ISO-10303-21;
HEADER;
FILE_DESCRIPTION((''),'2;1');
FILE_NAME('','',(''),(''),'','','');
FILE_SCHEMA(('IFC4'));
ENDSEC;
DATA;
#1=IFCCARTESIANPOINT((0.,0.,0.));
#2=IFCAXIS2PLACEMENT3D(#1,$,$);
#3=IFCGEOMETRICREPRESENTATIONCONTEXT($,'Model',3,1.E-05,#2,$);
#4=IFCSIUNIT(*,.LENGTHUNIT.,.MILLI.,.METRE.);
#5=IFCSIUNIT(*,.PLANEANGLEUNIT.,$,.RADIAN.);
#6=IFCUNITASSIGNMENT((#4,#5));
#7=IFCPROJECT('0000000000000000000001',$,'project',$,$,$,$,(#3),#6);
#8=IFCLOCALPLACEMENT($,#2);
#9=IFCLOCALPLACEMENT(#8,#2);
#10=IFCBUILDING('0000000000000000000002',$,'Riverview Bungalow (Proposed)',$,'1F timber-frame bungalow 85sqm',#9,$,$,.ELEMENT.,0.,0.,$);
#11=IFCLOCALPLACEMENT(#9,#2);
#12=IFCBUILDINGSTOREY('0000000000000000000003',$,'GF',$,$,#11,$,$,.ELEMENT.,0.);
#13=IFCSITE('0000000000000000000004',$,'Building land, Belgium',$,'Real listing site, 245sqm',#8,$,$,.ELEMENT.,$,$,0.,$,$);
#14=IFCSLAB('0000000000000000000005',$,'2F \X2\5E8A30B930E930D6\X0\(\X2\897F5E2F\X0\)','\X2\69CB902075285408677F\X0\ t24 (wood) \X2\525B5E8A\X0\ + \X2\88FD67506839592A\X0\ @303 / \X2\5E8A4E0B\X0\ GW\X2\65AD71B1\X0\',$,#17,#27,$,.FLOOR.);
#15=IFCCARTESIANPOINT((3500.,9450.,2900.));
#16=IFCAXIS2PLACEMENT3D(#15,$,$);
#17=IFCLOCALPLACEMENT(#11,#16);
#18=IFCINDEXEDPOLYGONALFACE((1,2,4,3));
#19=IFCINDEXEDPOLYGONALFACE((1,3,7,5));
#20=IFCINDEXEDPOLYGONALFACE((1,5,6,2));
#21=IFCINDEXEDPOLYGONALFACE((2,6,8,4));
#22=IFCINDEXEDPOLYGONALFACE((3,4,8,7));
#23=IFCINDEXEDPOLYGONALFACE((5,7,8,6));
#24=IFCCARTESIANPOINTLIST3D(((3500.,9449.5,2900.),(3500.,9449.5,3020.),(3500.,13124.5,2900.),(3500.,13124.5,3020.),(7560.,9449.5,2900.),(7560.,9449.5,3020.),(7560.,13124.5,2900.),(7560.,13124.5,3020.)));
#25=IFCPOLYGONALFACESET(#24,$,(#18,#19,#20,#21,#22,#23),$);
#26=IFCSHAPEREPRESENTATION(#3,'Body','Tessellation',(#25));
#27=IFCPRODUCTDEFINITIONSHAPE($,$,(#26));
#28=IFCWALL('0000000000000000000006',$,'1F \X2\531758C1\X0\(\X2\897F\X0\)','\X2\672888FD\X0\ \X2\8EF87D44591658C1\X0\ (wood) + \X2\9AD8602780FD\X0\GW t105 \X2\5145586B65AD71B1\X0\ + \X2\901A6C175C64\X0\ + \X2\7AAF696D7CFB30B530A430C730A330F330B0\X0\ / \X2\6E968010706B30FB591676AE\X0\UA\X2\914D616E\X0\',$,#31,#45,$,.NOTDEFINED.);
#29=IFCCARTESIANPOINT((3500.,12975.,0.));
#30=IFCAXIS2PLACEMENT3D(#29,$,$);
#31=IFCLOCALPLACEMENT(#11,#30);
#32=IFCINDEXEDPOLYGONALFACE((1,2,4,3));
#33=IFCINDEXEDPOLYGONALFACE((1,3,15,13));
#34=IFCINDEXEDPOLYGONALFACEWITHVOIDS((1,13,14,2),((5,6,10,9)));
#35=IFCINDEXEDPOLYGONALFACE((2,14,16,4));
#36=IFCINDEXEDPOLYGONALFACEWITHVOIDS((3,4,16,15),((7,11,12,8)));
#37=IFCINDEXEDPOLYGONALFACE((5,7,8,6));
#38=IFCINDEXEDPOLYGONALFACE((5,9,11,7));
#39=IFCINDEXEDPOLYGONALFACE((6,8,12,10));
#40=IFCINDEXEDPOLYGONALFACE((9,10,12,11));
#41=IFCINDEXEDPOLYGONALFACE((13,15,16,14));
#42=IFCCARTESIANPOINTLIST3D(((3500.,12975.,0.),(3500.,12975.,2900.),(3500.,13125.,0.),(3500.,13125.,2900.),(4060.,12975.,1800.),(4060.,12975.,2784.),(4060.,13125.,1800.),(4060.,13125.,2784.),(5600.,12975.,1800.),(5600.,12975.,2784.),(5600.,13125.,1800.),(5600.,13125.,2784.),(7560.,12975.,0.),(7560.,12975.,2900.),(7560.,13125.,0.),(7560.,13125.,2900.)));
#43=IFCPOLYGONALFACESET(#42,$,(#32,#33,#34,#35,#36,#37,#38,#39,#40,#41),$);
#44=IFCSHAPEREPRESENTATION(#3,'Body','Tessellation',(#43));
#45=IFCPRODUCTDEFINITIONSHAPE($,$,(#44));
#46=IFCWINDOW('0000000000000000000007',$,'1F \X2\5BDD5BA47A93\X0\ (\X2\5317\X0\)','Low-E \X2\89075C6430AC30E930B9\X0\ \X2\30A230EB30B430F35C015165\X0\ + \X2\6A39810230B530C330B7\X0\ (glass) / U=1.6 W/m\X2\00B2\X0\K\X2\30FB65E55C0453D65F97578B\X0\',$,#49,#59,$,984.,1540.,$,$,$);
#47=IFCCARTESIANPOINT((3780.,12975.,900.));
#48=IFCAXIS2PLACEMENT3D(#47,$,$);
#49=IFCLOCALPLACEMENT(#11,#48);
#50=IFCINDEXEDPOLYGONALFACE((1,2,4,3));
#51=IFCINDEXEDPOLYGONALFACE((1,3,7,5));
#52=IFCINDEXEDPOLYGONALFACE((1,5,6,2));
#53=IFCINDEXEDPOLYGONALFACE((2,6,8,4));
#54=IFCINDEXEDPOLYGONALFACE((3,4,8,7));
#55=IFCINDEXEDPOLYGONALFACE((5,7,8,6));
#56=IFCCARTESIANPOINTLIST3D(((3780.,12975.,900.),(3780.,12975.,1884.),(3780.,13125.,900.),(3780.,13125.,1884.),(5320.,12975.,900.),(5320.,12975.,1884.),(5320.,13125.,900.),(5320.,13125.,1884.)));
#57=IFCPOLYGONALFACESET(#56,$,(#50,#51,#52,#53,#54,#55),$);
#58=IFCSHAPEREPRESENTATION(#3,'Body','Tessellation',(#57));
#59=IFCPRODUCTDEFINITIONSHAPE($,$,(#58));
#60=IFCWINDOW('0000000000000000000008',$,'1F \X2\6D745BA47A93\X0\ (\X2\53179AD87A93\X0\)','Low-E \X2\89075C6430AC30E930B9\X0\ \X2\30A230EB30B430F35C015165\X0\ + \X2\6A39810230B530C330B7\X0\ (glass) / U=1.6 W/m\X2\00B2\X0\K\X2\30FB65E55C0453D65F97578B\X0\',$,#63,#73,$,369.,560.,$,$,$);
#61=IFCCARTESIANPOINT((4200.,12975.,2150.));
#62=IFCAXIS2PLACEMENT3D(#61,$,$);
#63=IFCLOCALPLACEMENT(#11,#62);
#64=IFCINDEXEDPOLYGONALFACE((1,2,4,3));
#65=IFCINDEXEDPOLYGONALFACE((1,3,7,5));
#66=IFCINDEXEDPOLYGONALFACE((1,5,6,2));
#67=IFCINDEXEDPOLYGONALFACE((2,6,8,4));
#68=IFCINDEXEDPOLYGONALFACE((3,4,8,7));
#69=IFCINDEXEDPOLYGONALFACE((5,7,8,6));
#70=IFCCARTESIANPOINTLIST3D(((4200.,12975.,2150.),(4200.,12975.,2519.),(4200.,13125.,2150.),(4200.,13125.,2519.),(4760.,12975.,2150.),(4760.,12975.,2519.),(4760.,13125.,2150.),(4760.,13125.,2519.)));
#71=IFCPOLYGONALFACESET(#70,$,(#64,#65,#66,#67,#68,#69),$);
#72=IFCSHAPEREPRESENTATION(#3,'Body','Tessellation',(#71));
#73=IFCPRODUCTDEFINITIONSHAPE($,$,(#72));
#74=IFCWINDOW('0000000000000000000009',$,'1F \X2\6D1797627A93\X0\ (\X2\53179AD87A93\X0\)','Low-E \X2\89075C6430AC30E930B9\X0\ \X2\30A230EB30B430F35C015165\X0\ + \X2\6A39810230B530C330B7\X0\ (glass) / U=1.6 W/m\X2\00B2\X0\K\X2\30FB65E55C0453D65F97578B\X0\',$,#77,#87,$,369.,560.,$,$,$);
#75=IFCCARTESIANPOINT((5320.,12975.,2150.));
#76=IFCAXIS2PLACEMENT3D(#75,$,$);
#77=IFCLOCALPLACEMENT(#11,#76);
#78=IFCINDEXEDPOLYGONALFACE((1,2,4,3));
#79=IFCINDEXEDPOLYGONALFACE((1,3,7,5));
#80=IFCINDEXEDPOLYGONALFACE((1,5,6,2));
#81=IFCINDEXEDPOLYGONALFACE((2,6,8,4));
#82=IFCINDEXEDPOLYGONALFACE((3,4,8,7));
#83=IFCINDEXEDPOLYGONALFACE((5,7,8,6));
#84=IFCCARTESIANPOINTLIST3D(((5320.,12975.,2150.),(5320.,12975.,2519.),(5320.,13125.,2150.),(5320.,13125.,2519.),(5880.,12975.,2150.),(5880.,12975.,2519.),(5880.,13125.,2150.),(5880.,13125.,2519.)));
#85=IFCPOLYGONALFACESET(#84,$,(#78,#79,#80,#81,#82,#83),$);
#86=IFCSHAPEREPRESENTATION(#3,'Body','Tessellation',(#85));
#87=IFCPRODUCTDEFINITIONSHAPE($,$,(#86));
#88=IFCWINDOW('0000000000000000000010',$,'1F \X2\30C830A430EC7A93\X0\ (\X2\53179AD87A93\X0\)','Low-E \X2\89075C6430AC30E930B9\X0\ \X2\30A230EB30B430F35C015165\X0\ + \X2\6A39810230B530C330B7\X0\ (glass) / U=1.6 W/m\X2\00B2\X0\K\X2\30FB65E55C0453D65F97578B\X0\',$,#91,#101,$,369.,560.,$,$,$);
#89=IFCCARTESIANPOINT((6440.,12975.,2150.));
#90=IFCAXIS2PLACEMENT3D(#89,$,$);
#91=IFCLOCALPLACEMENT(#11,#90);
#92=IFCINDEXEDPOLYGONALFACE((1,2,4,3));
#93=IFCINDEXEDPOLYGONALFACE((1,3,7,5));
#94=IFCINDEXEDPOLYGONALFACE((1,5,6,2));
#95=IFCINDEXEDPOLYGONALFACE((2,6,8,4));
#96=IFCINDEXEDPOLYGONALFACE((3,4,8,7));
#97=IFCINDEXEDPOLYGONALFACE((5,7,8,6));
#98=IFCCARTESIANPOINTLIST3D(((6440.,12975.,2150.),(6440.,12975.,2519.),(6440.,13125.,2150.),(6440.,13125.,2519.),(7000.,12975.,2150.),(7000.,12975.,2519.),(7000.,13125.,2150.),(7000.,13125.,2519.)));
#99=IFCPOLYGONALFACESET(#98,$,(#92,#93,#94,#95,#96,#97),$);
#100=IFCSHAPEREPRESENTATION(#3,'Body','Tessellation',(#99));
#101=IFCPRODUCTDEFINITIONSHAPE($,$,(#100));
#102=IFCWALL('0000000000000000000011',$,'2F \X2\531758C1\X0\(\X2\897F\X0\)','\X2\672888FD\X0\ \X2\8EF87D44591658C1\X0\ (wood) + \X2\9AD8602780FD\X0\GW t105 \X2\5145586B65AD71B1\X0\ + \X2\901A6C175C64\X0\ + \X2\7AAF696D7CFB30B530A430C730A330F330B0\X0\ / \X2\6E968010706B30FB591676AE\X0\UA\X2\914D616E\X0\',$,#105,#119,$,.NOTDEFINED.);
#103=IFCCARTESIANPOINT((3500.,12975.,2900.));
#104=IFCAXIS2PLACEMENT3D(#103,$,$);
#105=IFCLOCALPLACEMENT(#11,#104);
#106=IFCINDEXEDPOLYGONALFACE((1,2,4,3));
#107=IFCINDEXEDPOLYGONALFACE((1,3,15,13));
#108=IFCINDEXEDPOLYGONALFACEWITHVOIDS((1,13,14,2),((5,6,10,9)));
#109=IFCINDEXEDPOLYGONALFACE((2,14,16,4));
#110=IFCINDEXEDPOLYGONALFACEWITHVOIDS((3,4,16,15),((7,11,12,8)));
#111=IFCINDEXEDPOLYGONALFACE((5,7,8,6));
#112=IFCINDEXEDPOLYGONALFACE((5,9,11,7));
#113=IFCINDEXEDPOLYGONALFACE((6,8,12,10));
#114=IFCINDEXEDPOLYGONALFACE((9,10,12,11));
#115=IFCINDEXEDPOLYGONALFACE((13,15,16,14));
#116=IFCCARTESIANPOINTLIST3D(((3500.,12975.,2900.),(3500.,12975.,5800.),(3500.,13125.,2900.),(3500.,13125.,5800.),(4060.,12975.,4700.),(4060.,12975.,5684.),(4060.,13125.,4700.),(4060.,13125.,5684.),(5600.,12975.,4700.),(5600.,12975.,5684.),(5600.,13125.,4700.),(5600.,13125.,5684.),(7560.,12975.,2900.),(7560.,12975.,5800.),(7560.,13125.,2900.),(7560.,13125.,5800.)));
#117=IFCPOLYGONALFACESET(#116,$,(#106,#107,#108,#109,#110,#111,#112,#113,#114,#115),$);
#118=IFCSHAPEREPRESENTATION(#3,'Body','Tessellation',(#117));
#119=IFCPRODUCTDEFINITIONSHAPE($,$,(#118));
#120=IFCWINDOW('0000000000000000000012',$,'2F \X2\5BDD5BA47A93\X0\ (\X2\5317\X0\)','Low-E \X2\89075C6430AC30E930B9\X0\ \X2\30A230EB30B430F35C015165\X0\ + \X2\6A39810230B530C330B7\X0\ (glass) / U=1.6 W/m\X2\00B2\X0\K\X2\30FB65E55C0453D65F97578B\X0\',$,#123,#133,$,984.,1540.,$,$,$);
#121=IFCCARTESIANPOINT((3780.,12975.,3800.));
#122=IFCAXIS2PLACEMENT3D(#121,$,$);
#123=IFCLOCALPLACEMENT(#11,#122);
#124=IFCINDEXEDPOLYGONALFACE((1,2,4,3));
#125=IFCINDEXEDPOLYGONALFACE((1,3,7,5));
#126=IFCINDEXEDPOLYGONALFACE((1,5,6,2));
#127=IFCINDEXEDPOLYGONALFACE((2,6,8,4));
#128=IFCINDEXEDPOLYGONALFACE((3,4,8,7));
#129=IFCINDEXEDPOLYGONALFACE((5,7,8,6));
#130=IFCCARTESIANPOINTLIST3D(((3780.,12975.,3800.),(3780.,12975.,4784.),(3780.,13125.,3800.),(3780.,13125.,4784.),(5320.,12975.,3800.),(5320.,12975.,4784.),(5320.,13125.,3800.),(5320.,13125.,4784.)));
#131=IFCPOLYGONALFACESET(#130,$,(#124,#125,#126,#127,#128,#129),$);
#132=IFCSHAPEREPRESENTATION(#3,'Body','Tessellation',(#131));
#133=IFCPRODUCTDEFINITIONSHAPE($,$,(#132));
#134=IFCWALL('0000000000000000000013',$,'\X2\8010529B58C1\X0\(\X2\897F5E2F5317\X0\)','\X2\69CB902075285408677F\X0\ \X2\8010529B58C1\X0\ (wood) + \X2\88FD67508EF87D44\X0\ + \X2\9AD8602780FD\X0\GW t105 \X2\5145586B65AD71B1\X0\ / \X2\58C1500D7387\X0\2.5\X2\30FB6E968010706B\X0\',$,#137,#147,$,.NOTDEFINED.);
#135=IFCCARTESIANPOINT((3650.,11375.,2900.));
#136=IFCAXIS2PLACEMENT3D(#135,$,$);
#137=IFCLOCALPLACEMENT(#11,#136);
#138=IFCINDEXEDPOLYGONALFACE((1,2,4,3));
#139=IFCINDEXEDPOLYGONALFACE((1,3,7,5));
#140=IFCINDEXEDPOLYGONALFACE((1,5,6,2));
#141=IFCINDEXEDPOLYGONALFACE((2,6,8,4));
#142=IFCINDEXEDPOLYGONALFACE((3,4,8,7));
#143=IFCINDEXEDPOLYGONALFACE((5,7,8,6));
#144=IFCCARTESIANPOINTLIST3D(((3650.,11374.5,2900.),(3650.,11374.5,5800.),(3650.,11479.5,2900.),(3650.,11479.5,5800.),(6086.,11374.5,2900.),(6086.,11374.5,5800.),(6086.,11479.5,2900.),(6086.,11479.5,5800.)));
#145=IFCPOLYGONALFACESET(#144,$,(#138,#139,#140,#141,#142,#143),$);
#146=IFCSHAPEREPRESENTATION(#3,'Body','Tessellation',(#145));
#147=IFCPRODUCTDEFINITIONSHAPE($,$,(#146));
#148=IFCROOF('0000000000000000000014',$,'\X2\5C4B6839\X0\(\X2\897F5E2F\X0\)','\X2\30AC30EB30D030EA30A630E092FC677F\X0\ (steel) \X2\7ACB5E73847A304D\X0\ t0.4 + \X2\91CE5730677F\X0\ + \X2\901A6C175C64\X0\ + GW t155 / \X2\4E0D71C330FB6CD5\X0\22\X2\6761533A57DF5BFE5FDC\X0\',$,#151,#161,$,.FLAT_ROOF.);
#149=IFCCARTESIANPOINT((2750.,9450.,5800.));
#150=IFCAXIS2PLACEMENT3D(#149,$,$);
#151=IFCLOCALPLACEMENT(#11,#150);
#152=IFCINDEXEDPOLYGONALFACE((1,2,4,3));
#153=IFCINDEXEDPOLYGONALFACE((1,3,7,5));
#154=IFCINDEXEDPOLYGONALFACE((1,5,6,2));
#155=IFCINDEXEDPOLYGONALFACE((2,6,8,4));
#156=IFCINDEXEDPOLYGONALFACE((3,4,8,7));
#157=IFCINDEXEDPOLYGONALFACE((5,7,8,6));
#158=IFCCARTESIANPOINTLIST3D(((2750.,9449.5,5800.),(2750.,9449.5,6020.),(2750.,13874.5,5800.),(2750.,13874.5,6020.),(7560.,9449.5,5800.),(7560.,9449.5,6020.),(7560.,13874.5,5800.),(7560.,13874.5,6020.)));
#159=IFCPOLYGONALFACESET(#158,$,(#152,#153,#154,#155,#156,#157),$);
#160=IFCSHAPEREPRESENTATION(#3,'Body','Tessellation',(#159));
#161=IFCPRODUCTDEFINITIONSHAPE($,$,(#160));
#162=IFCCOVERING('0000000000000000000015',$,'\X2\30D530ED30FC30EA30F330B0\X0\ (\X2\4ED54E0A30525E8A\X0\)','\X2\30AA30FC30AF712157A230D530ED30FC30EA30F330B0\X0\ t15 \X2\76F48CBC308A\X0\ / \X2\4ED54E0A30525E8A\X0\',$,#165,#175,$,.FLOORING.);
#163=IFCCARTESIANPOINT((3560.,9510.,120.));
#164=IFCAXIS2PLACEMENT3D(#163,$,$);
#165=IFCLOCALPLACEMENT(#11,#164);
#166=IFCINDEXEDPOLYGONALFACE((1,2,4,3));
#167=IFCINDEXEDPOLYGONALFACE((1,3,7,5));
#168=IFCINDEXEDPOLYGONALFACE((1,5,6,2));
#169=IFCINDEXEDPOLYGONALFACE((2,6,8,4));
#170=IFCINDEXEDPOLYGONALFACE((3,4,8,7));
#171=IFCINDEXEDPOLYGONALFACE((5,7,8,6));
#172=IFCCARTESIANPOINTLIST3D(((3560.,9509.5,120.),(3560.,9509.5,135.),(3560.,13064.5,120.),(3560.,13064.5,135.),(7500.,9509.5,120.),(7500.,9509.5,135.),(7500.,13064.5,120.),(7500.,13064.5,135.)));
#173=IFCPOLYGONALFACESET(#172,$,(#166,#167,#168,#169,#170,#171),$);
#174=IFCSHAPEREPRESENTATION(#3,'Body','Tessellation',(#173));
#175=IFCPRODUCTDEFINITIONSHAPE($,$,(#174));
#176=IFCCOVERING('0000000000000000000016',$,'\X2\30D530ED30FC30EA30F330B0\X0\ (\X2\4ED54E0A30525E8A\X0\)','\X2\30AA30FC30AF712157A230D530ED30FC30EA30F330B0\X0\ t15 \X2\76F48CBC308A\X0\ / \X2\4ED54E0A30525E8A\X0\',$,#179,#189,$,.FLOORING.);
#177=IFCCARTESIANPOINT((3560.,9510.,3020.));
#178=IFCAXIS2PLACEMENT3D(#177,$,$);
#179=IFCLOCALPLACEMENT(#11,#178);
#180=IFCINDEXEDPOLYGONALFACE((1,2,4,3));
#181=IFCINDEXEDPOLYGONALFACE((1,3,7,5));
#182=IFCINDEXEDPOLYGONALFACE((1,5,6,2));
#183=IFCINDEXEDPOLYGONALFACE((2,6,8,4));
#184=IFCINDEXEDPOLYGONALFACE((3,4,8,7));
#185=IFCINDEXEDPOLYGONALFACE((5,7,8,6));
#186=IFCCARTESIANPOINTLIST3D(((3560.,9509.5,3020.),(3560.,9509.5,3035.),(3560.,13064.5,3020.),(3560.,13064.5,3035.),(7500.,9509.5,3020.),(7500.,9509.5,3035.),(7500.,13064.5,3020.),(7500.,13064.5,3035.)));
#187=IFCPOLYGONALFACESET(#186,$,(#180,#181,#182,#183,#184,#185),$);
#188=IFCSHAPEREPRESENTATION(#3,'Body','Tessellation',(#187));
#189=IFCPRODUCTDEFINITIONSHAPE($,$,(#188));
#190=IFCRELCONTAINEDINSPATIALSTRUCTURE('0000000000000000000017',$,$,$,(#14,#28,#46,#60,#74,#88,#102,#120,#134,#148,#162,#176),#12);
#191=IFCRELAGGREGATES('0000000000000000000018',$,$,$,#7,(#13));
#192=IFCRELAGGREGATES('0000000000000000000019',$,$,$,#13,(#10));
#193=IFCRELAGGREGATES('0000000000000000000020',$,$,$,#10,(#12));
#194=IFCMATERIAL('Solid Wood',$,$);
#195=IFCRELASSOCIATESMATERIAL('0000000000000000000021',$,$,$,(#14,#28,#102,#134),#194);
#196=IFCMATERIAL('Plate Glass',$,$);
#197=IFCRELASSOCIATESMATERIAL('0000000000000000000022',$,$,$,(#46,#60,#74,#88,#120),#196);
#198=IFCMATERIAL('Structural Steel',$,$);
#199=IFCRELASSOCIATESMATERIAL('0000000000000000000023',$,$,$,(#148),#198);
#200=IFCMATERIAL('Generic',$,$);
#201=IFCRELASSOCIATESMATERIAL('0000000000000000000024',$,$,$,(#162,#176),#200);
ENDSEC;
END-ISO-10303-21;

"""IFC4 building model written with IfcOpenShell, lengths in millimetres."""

from ifc_helpers import new_model, si_unit, frame, frame_2d, origin, place, context, project, spatial, rectangle, extrude, material, element, fill, save


model = new_model("IFC4")

# Units and contexts
model_context = context("Model", 3, precision=1e-05, world=origin())
ifc_project = project(units=[si_unit("LENGTHUNIT", "METRE", prefix="MILLI"), si_unit("PLANEANGLEUNIT", "RADIAN")], contexts=[model_context])

# Site, building, storey
site_placement = place(None, origin())
site = spatial("IfcSite", under=ifc_project, at=site_placement, Name="Building land, Belgium", ObjectType="Real listing site, 245sqm", CompositionType="ELEMENT", RefElevation=0.0)
building_placement = place(site_placement, origin())
building = spatial("IfcBuilding", under=site, at=building_placement, Name="Riverview Bungalow (Proposed)", ObjectType="1F timber-frame bungalow 85sqm", CompositionType="ELEMENT", ElevationOfRefHeight=0.0, ElevationOfTerrain=0.0)
storey_placement = place(building_placement, origin())
storey = spatial("IfcBuildingStorey", under=building, at=storey_placement, Name="GF", CompositionType="ELEMENT", Elevation=0.0)

# Slab
ifc_material_1 = material(Name="Solid Wood")
slab_1_placement = place(storey_placement, frame((3500.0, 9450.0, 2900.0)))
element("IfcSlab", 1, at=slab_1_placement, inside=storey, material=ifc_material_1, Name="2F 床スラブ(西帯)", Description="構造用合板 t24 (wood) 剛床 + 製材根太 @303 / 床下 GW断熱", PredefinedType="FLOOR", context=model_context, shape_type="SweptSolid", body=[
    extrude(rectangle(XDim=4060.0, YDim=3675.0, at=frame_2d((2030.0, 1837.0))), frame((3500.0, 9450.0, 2900.0)), (0.0, 0.0, 1.0), 120.0),
])

# Wall, openings, windows
wall_1_placement = place(storey_placement, frame((3500.0, 12975.0, 0.0)))
wall_1 = element("IfcWall", 2, at=wall_1_placement, inside=storey, material=ifc_material_1, Name="1F 北壁(西)", Description="木製 軸組外壁 (wood) + 高性能GW t105 充填断熱 + 通気層 + 窯業系サイディング / 準耐火・外皮UA配慮", PredefinedType="NOTDEFINED", context=model_context, shape_type="SweptSolid", body=[
    extrude(rectangle(XDim=4060.0, YDim=150.0, at=frame_2d((2030.0, 75.0))), frame((3500.0, 12975.0, 0.0)), (0.0, 0.0, 1.0), 2900.0),
])
opening_1_placement = place(storey_placement, frame((3780.0, 12975.0, 900.0)))
opening_1 = element("IfcOpeningElement", 3, at=opening_1_placement, cuts=wall_1, PredefinedType="NOTDEFINED", context=model_context, shape_type="SweptSolid", body=[
    extrude(rectangle(XDim=1540.0, YDim=150.0, at=frame_2d((770.0, 75.0))), frame((3780.0, 12975.0, 900.0)), (0.0, 0.0, 1.0), 984.0),
])
opening_2_placement = place(storey_placement, frame((4200.0, 12975.0, 2150.0)))
opening_2 = element("IfcOpeningElement", 4, at=opening_2_placement, cuts=wall_1, PredefinedType="NOTDEFINED", context=model_context, shape_type="SweptSolid", body=[
    extrude(rectangle(XDim=560.0, YDim=150.0, at=frame_2d((280.0, 75.0))), frame((4200.0, 12975.0, 2150.0)), (0.0, 0.0, 1.0), 369.0),
])
opening_3_placement = place(storey_placement, frame((5320.0, 12975.0, 2150.0)))
opening_3 = element("IfcOpeningElement", 5, at=opening_3_placement, cuts=wall_1, PredefinedType="NOTDEFINED", context=model_context, shape_type="SweptSolid", body=[
    extrude(rectangle(XDim=560.0, YDim=150.0, at=frame_2d((280.0, 75.0))), frame((5320.0, 12975.0, 2150.0)), (0.0, 0.0, 1.0), 369.0),
])
opening_4_placement = place(storey_placement, frame((6440.0, 12975.0, 2150.0)))
opening_4 = element("IfcOpeningElement", 6, at=opening_4_placement, cuts=wall_1, PredefinedType="NOTDEFINED", context=model_context, shape_type="SweptSolid", body=[
    extrude(rectangle(XDim=560.0, YDim=150.0, at=frame_2d((280.0, 75.0))), frame((6440.0, 12975.0, 2150.0)), (0.0, 0.0, 1.0), 369.0),
])
ifc_material_2 = material(Name="Plate Glass")
window_1_placement = place(storey_placement, frame((3780.0, 12975.0, 900.0)))
window_1 = element("IfcWindow", 7, at=window_1_placement, inside=storey, material=ifc_material_2, Name="1F 寝室窓 (北)", Description="Low-E 複層ガラス アルゴン封入 + 樹脂サッシ (glass) / U=1.6 W/m²K・日射取得型", OverallHeight=984.0, OverallWidth=1540.0, context=model_context, shape_type="SweptSolid", body=[
    extrude(rectangle(XDim=1540.0, YDim=150.0, at=frame_2d((770.0, 75.0))), frame((3780.0, 12975.0, 900.0)), (0.0, 0.0, 1.0), 984.0),
])
fill(opening_1, window_1)
window_2_placement = place(storey_placement, frame((4200.0, 12975.0, 2150.0)))
window_2 = element("IfcWindow", 8, at=window_2_placement, inside=storey, material=ifc_material_2, Name="1F 浴室窓 (北高窓)", Description="Low-E 複層ガラス アルゴン封入 + 樹脂サッシ (glass) / U=1.6 W/m²K・日射取得型", OverallHeight=369.0, OverallWidth=560.0, context=model_context, shape_type="SweptSolid", body=[
    extrude(rectangle(XDim=560.0, YDim=150.0, at=frame_2d((280.0, 75.0))), frame((4200.0, 12975.0, 2150.0)), (0.0, 0.0, 1.0), 369.0),
])
fill(opening_2, window_2)
window_3_placement = place(storey_placement, frame((5320.0, 12975.0, 2150.0)))
window_3 = element("IfcWindow", 9, at=window_3_placement, inside=storey, material=ifc_material_2, Name="1F 洗面窓 (北高窓)", Description="Low-E 複層ガラス アルゴン封入 + 樹脂サッシ (glass) / U=1.6 W/m²K・日射取得型", OverallHeight=369.0, OverallWidth=560.0, context=model_context, shape_type="SweptSolid", body=[
    extrude(rectangle(XDim=560.0, YDim=150.0, at=frame_2d((280.0, 75.0))), frame((5320.0, 12975.0, 2150.0)), (0.0, 0.0, 1.0), 369.0),
])
fill(opening_3, window_3)
window_4_placement = place(storey_placement, frame((6440.0, 12975.0, 2150.0)))
window_4 = element("IfcWindow", 10, at=window_4_placement, inside=storey, material=ifc_material_2, Name="1F トイレ窓 (北高窓)", Description="Low-E 複層ガラス アルゴン封入 + 樹脂サッシ (glass) / U=1.6 W/m²K・日射取得型", OverallHeight=369.0, OverallWidth=560.0, context=model_context, shape_type="SweptSolid", body=[
    extrude(rectangle(XDim=560.0, YDim=150.0, at=frame_2d((280.0, 75.0))), frame((6440.0, 12975.0, 2150.0)), (0.0, 0.0, 1.0), 369.0),
])
fill(opening_4, window_4)

# Wall, opening, window
wall_2_placement = place(storey_placement, frame((3500.0, 12975.0, 2900.0)))
wall_2 = element("IfcWall", 11, at=wall_2_placement, inside=storey, material=ifc_material_1, Name="2F 北壁(西)", Description="木製 軸組外壁 (wood) + 高性能GW t105 充填断熱 + 通気層 + 窯業系サイディング / 準耐火・外皮UA配慮", PredefinedType="NOTDEFINED", context=model_context, shape_type="SweptSolid", body=[
    extrude(rectangle(XDim=4060.0, YDim=150.0, at=frame_2d((2030.0, 75.0))), frame((3500.0, 12975.0, 2900.0)), (0.0, 0.0, 1.0), 2900.0),
])
opening_5_placement = place(storey_placement, frame((3780.0, 12975.0, 3800.0)))
opening_5 = element("IfcOpeningElement", 12, at=opening_5_placement, cuts=wall_2, PredefinedType="NOTDEFINED", context=model_context, shape_type="SweptSolid", body=[
    extrude(rectangle(XDim=1540.0, YDim=150.0, at=frame_2d((770.0, 75.0))), frame((3780.0, 12975.0, 3800.0)), (0.0, 0.0, 1.0), 984.0),
])
window_5_placement = place(storey_placement, frame((3780.0, 12975.0, 3800.0)))
window_5 = element("IfcWindow", 13, at=window_5_placement, inside=storey, material=ifc_material_2, Name="2F 寝室窓 (北)", Description="Low-E 複層ガラス アルゴン封入 + 樹脂サッシ (glass) / U=1.6 W/m²K・日射取得型", OverallHeight=984.0, OverallWidth=1540.0, context=model_context, shape_type="SweptSolid", body=[
    extrude(rectangle(XDim=1540.0, YDim=150.0, at=frame_2d((770.0, 75.0))), frame((3780.0, 12975.0, 3800.0)), (0.0, 0.0, 1.0), 984.0),
])
fill(opening_5, window_5)

# Wall
wall_3_placement = place(storey_placement, frame((3650.0, 11375.0, 2900.0)))
element("IfcWall", 14, at=wall_3_placement, inside=storey, material=ifc_material_1, Name="耐力壁(西帯北)", Description="構造用合板 耐力壁 (wood) + 製材軸組 + 高性能GW t105 充填断熱 / 壁倍率2.5・準耐火", PredefinedType="NOTDEFINED", context=model_context, shape_type="SweptSolid", body=[
    extrude(rectangle(XDim=2436.0, YDim=105.0, at=frame_2d((1218.0, 52.0))), frame((3650.0, 11375.0, 2900.0)), (0.0, 0.0, 1.0), 2900.0),
])

# Roof
ifc_material_3 = material(Name="Structural Steel")
for number, where, name in (
    (15, (2750.0, 9450.0, 5800.0), "屋根(西帯)"),
):
    element("IfcRoof", number, at=place(storey_placement, frame(where)), inside=storey, material=ifc_material_3, Name=name, Description="ガルバリウム鋼板 (steel) 立平葺き t0.4 + 野地板 + 通気層 + GW t155 / 不燃・法22条区域対応", PredefinedType="FLAT_ROOF", context=model_context, shape_type="SweptSolid", body=[
        extrude(rectangle(XDim=4810.0, YDim=4425.0, at=frame_2d((2405.0, 2212.0))), frame((2750.0, 9450.0, 5800.0)), (0.0, 0.0, 1.0), 220.0),
    ])

# Coverings
ifc_material_4 = material(Name="Generic")
covering_1_placement = place(storey_placement, frame((3560.0, 9510.0, 120.0)))
element("IfcCovering", 16, at=covering_1_placement, inside=storey, material=ifc_material_4, Name="フローリング (仕上げ床)", Description="オーク無垢フローリング t15 直貼り / 仕上げ床", PredefinedType="FLOORING", context=model_context, shape_type="SweptSolid", body=[
    extrude(rectangle(XDim=3940.0, YDim=3555.0, at=frame_2d((1970.0, 1777.0))), frame((3560.0, 9510.0, 120.0)), (0.0, 0.0, 1.0), 15.0),
])
covering_2_placement = place(storey_placement, frame((3560.0, 9510.0, 3020.0)))
element("IfcCovering", 17, at=covering_2_placement, inside=storey, material=ifc_material_4, Name="フローリング (仕上げ床)", Description="オーク無垢フローリング t15 直貼り / 仕上げ床", PredefinedType="FLOORING", context=model_context, shape_type="SweptSolid", body=[
    extrude(rectangle(XDim=3940.0, YDim=3555.0, at=frame_2d((1970.0, 1777.0))), frame((3560.0, 9510.0, 3020.0)), (0.0, 0.0, 1.0), 15.0),
])

save(model, "model.ifc")
